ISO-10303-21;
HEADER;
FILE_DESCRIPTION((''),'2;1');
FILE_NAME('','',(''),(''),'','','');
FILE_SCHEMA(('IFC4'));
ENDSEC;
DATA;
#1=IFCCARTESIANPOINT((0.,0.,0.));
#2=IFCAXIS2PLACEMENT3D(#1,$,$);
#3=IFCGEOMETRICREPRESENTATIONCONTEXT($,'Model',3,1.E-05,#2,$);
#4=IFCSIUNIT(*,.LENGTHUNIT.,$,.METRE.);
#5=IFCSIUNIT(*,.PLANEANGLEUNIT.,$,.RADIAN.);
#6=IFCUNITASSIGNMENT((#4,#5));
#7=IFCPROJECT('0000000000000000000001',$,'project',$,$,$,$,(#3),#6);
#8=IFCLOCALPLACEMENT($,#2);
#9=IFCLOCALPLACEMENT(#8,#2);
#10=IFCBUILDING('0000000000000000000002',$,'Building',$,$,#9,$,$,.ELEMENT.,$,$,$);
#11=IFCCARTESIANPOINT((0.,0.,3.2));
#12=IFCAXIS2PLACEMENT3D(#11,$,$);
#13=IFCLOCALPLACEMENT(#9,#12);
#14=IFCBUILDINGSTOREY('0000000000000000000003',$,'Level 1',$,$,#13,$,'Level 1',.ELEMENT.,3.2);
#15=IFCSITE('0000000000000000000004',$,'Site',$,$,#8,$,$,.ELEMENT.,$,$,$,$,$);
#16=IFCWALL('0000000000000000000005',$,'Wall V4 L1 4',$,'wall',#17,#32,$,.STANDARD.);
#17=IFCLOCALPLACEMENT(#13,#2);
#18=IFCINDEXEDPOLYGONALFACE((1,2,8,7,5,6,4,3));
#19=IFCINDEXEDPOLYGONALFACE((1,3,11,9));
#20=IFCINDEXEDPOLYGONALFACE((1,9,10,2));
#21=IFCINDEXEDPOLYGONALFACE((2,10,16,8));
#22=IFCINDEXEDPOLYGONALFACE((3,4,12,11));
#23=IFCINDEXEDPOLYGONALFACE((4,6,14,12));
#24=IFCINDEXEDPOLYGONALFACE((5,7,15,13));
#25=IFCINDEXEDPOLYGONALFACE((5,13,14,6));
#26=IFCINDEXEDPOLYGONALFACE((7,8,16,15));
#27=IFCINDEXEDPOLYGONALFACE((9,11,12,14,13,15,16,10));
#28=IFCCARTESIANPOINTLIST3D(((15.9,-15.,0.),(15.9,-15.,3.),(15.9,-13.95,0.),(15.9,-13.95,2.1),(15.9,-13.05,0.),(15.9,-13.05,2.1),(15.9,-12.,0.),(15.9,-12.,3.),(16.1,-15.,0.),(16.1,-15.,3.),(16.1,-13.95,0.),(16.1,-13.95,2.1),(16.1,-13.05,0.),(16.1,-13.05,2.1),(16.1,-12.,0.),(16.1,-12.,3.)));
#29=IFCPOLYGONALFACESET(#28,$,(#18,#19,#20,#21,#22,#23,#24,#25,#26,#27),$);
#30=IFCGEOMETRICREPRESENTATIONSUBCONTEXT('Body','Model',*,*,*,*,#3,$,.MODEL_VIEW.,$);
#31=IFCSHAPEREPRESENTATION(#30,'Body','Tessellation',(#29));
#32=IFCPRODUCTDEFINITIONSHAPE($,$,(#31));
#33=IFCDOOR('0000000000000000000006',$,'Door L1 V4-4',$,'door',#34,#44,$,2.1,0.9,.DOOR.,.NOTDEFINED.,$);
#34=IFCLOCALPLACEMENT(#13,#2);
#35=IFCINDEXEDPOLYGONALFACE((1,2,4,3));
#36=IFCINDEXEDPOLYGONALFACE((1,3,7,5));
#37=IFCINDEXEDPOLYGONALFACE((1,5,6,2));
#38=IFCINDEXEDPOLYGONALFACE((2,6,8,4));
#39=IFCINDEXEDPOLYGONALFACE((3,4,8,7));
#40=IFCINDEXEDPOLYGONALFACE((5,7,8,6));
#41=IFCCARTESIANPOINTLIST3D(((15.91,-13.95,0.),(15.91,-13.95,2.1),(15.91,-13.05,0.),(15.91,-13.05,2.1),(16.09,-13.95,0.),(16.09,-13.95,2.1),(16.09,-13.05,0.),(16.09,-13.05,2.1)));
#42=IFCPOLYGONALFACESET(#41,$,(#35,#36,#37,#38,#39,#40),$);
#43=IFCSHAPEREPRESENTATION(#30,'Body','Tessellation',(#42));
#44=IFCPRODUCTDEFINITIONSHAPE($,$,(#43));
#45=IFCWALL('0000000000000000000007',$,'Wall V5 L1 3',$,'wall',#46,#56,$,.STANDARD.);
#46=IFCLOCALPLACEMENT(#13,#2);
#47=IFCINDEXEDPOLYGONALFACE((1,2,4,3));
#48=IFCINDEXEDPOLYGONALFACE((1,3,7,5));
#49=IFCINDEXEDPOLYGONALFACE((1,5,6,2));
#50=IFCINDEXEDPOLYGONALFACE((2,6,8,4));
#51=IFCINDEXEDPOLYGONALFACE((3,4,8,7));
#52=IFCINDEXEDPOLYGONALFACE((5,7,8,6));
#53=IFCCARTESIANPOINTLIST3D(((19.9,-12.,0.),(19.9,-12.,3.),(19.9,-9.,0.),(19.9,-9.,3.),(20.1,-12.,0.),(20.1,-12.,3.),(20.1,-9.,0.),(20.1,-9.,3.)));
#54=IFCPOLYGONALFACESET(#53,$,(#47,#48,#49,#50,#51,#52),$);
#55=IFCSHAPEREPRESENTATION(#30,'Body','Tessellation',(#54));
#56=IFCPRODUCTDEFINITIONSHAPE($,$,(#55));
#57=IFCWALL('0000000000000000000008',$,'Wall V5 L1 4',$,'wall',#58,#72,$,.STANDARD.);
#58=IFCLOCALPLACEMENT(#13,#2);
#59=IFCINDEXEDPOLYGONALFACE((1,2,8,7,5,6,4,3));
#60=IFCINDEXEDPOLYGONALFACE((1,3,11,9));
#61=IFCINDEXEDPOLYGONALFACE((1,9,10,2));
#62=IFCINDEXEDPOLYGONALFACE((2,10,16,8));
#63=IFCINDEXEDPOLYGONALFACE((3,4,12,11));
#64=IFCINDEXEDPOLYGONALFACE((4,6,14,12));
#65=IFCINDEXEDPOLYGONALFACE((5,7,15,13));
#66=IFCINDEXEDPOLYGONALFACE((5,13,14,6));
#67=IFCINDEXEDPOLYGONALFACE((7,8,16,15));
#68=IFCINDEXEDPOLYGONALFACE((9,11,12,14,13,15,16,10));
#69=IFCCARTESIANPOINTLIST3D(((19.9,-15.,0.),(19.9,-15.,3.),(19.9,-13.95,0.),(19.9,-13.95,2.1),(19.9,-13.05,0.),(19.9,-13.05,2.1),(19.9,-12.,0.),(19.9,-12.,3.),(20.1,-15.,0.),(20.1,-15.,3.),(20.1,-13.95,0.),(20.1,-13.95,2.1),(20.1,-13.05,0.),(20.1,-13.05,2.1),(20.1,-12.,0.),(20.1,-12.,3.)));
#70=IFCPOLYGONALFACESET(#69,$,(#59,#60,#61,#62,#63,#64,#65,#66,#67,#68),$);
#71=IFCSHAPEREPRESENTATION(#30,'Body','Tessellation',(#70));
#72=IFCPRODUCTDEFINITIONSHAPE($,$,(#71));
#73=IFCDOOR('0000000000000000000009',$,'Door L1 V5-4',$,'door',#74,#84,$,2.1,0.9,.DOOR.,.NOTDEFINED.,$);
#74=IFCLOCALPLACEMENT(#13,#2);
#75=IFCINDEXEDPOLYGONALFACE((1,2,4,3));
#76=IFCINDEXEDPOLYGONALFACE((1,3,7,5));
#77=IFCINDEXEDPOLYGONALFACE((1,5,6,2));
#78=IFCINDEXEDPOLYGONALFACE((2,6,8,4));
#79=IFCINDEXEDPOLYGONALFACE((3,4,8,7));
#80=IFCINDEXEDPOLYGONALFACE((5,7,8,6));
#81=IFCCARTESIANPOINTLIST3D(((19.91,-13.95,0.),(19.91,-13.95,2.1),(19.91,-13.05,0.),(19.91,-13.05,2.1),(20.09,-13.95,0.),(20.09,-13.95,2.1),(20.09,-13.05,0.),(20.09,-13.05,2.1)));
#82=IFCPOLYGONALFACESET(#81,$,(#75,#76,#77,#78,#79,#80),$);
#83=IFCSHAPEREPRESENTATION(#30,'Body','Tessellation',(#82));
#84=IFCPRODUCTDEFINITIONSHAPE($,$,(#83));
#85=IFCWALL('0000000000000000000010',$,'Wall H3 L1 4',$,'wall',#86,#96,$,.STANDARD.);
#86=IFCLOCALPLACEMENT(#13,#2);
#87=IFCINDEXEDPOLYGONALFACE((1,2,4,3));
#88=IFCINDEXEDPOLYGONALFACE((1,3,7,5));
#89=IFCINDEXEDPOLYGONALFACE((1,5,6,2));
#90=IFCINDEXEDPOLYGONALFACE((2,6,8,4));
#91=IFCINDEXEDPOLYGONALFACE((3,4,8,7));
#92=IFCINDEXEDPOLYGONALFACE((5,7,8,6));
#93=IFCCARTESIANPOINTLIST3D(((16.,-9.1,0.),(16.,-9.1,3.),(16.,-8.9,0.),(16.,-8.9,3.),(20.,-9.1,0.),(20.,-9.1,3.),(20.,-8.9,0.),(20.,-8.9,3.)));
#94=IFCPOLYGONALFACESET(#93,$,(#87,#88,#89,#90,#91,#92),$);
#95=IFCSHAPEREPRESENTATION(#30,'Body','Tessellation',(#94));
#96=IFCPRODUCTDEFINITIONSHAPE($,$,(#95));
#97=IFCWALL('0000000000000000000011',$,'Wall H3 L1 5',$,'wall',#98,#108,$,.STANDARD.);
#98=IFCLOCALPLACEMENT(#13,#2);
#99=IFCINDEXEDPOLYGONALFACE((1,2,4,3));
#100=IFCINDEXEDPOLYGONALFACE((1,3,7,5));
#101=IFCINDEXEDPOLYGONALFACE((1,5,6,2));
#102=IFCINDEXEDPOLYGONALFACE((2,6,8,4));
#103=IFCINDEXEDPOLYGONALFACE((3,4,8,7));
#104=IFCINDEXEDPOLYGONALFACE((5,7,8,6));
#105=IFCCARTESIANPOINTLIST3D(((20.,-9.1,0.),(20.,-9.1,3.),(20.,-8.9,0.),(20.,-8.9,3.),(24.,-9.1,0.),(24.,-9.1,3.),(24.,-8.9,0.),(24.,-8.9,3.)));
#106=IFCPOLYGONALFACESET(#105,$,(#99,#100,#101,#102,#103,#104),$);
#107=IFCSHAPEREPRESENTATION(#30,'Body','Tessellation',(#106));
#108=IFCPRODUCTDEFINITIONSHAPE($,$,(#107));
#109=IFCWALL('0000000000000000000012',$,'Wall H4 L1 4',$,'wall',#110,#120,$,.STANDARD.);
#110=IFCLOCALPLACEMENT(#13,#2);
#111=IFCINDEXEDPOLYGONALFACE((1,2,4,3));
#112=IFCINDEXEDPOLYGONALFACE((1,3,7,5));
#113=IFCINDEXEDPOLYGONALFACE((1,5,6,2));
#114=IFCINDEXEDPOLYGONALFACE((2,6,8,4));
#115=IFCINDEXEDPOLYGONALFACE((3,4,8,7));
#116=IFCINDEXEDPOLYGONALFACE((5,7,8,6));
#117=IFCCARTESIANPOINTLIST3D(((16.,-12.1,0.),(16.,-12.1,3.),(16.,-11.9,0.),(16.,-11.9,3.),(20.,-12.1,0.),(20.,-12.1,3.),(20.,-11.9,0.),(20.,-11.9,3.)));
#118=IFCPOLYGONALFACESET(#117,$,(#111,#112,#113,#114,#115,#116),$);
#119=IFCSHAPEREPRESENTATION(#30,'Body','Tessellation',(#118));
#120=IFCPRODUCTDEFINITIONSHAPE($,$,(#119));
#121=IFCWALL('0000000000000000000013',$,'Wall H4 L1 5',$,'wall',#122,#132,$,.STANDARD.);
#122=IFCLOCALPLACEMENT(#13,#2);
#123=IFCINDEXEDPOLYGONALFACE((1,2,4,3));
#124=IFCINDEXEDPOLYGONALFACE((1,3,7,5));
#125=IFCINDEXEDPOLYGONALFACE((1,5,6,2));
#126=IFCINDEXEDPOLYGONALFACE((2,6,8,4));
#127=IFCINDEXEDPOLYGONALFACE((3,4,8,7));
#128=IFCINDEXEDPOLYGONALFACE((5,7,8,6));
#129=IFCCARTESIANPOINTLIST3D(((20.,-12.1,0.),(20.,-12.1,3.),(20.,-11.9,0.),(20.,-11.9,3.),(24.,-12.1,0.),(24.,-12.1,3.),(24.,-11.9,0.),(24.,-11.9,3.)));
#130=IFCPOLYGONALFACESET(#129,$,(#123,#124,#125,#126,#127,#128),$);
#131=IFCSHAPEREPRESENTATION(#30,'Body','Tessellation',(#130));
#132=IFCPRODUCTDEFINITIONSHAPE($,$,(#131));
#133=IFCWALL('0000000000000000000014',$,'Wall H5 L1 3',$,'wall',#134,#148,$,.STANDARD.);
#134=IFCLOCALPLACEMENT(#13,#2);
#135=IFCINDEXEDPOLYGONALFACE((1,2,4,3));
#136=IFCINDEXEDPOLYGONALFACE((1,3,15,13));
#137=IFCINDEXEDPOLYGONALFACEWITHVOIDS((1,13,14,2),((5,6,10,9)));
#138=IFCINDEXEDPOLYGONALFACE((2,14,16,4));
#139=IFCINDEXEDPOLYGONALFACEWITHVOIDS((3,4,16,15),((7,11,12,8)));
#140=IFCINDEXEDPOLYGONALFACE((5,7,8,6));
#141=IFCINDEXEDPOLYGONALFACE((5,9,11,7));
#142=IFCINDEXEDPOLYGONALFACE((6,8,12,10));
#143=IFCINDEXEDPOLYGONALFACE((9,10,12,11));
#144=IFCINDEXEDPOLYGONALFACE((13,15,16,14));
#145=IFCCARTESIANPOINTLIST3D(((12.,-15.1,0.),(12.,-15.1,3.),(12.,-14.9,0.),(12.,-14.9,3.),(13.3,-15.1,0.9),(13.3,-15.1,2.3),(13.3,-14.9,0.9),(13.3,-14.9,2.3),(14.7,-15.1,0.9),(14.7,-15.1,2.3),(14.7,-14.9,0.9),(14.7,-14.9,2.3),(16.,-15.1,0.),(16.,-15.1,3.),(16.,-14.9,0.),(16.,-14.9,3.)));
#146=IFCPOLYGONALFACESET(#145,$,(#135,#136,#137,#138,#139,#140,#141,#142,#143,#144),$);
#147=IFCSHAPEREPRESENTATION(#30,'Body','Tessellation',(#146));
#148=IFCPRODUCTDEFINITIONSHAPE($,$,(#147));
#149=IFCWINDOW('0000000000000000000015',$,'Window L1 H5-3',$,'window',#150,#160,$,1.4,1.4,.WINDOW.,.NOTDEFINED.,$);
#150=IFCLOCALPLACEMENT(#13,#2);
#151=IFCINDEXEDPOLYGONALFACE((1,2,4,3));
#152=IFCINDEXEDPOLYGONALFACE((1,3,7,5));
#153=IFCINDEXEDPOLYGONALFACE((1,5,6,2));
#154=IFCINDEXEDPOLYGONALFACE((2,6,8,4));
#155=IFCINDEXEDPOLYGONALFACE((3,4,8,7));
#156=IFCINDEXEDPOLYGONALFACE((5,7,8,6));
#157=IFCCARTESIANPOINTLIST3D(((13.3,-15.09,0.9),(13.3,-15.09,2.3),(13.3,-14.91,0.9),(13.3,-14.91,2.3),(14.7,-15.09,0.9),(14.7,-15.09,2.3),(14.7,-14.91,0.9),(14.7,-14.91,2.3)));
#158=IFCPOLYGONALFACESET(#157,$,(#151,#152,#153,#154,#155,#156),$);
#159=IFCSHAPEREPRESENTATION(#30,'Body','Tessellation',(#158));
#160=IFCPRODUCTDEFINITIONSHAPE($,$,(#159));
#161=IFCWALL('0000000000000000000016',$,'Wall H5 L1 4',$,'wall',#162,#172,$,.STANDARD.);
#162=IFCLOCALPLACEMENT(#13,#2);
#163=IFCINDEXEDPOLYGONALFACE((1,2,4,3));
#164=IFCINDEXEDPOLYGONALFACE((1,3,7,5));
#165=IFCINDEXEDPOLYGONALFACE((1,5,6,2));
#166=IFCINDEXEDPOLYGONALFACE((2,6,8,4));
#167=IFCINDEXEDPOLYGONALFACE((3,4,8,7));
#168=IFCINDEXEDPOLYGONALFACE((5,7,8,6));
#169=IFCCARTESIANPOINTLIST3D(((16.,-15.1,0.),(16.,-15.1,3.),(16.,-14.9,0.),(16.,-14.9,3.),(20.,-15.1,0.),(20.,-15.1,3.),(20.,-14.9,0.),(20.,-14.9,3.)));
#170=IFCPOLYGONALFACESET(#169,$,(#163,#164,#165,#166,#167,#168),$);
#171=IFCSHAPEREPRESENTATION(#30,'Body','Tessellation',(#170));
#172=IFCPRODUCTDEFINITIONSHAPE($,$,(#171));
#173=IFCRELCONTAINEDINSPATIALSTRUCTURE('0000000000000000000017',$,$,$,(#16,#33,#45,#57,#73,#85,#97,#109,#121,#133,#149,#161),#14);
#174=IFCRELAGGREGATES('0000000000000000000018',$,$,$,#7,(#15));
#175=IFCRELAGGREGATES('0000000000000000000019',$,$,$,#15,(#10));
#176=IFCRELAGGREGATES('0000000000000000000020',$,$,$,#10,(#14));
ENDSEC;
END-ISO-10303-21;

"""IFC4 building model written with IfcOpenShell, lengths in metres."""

from ifc_helpers import new_model, si_unit, frame, frame_2d, origin, origin_2d, place, context, subcontext, project, spatial, rectangle, extrude, element, fill, save


model = new_model("IFC4")

# Units and contexts
model_context = context("Model", 3, precision=1e-05, world=origin())
body_context = subcontext(model_context, "Body", "Model", "MODEL_VIEW")
ifc_project = project(units=[si_unit("LENGTHUNIT", "METRE"), si_unit("PLANEANGLEUNIT", "RADIAN")], contexts=[model_context])

# Site, building, storey
site_placement = place(None, origin())
site = spatial("IfcSite", under=ifc_project, at=site_placement, Name="Site", CompositionType="ELEMENT")
building_placement = place(site_placement, origin())
building = spatial("IfcBuilding", under=site, at=building_placement, Name="Building", CompositionType="ELEMENT")
storey_placement = place(building_placement, frame((0.0, 0.0, 3.2)))
storey = spatial("IfcBuildingStorey", under=building, at=storey_placement, Name="Level 1", LongName="Level 1", CompositionType="ELEMENT", Elevation=3.2)

# Wall, opening, door
wall_1_placement = place(storey_placement, frame((16.0, -12.0, 0.0), z_axis=(0.0, 0.0, 1.0), x_axis=(0.0, -1.0, 0.0)))
wall_1 = element("IfcWall", 1, at=wall_1_placement, inside=storey, Name="Wall V4 L1 4", ObjectType="wall", PredefinedType="STANDARD", context=body_context, shape_type="SweptSolid", body=[
    extrude(rectangle(XDim=3.0, YDim=0.2, at=frame_2d((1.5, 0.0))), origin(), (0.0, 0.0, 1.0), 3.0),
])
opening_1_placement = place(storey_placement, frame((16.0, -13.5, 0.0), z_axis=(0.0, 0.0, 1.0), x_axis=(0.0, -1.0, 0.0)))
opening_1 = element("IfcOpeningElement", 2, at=opening_1_placement, cuts=wall_1, ObjectType="Opening", PredefinedType="OPENING", context=body_context, shape_type="SweptSolid", body=[
    extrude(rectangle(XDim=0.9, YDim=0.22, at=origin_2d()), origin(), (0.0, 0.0, 1.0), 2.1),
])
door_1_placement = place(storey_placement, frame((16.0, -13.5, 0.0), z_axis=(0.0, 0.0, 1.0), x_axis=(0.0, -1.0, 0.0)))
door_1 = element("IfcDoor", 3, at=door_1_placement, inside=storey, Name="Door L1 V4-4", ObjectType="door", OperationType="NOTDEFINED", OverallHeight=2.1, OverallWidth=0.9, PredefinedType="DOOR", context=body_context, shape_type="SweptSolid", body=[
    extrude(rectangle(XDim=0.9, YDim=0.18, at=origin_2d()), origin(), (0.0, 0.0, 1.0), 2.1),
])
fill(opening_1, door_1)

# Wall
wall_2_placement = place(storey_placement, frame((20.0, -9.0, 0.0), z_axis=(0.0, 0.0, 1.0), x_axis=(0.0, -1.0, 0.0)))
element("IfcWall", 4, at=wall_2_placement, inside=storey, Name="Wall V5 L1 3", ObjectType="wall", PredefinedType="STANDARD", context=body_context, shape_type="SweptSolid", body=[
    extrude(rectangle(XDim=3.0, YDim=0.2, at=frame_2d((1.5, 0.0))), origin(), (0.0, 0.0, 1.0), 3.0),
])

# Wall, opening, door
wall_3_placement = place(storey_placement, frame((20.0, -12.0, 0.0), z_axis=(0.0, 0.0, 1.0), x_axis=(0.0, -1.0, 0.0)))
wall_3 = element("IfcWall", 5, at=wall_3_placement, inside=storey, Name="Wall V5 L1 4", ObjectType="wall", PredefinedType="STANDARD", context=body_context, shape_type="SweptSolid", body=[
    extrude(rectangle(XDim=3.0, YDim=0.2, at=frame_2d((1.5, 0.0))), origin(), (0.0, 0.0, 1.0), 3.0),
])
opening_2_placement = place(storey_placement, frame((20.0, -13.5, 0.0), z_axis=(0.0, 0.0, 1.0), x_axis=(0.0, -1.0, 0.0)))
opening_2 = element("IfcOpeningElement", 6, at=opening_2_placement, cuts=wall_3, ObjectType="Opening", PredefinedType="OPENING", context=body_context, shape_type="SweptSolid", body=[
    extrude(rectangle(XDim=0.9, YDim=0.22, at=origin_2d()), origin(), (0.0, 0.0, 1.0), 2.1),
])
door_2_placement = place(storey_placement, frame((20.0, -13.5, 0.0), z_axis=(0.0, 0.0, 1.0), x_axis=(0.0, -1.0, 0.0)))
door_2 = element("IfcDoor", 7, at=door_2_placement, inside=storey, Name="Door L1 V5-4", ObjectType="door", OperationType="NOTDEFINED", OverallHeight=2.1, OverallWidth=0.9, PredefinedType="DOOR", context=body_context, shape_type="SweptSolid", body=[
    extrude(rectangle(XDim=0.9, YDim=0.18, at=origin_2d()), origin(), (0.0, 0.0, 1.0), 2.1),
])
fill(opening_2, door_2)

# Walls
for number, where, z_axis, x_axis, name in (
    (8, (16.0, -9.0, 0.0), (0.0, 0.0, 1.0), (1.0, 0.0, 0.0), "Wall H3 L1 4"),
    (9, (20.0, -9.0, 0.0), (0.0, 0.0, 1.0), (1.0, 0.0, 0.0), "Wall H3 L1 5"),
    (10, (16.0, -12.0, 0.0), (0.0, 0.0, 1.0), (1.0, 0.0, 0.0), "Wall H4 L1 4"),
    (11, (20.0, -12.0, 0.0), (0.0, 0.0, 1.0), (1.0, 0.0, 0.0), "Wall H4 L1 5"),
):
    element("IfcWall", number, at=place(storey_placement, frame(where, z_axis=z_axis, x_axis=x_axis)), inside=storey, Name=name, ObjectType="wall", PredefinedType="STANDARD", context=body_context, shape_type="SweptSolid", body=[
        extrude(rectangle(XDim=4.0, YDim=0.2, at=frame_2d((2.0, 0.0))), origin(), (0.0, 0.0, 1.0), 3.0),
    ])

# Wall, opening, window
wall_4_placement = place(storey_placement, frame((12.0, -15.0, 0.0), z_axis=(0.0, 0.0, 1.0), x_axis=(1.0, 0.0, 0.0)))
wall_4 = element("IfcWall", 12, at=wall_4_placement, inside=storey, Name="Wall H5 L1 3", ObjectType="wall", PredefinedType="STANDARD", context=body_context, shape_type="SweptSolid", body=[
    extrude(rectangle(XDim=4.0, YDim=0.2, at=frame_2d((2.0, 0.0))), origin(), (0.0, 0.0, 1.0), 3.0),
])
opening_3_placement = place(storey_placement, frame((14.0, -15.0, 0.9), z_axis=(0.0, 0.0, 1.0), x_axis=(1.0, 0.0, 0.0)))
opening_3 = element("IfcOpeningElement", 13, at=opening_3_placement, cuts=wall_4, ObjectType="Opening", PredefinedType="OPENING", context=body_context, shape_type="SweptSolid", body=[
    extrude(rectangle(XDim=1.4, YDim=0.22, at=origin_2d()), origin(), (0.0, 0.0, 1.0), 1.4),
])
window_1_placement = place(storey_placement, frame((14.0, -15.0, 0.9), z_axis=(0.0, 0.0, 1.0), x_axis=(1.0, 0.0, 0.0)))
window_1 = element("IfcWindow", 14, at=window_1_placement, inside=storey, Name="Window L1 H5-3", ObjectType="window", OverallHeight=1.4, OverallWidth=1.4, PartitioningType="NOTDEFINED", PredefinedType="WINDOW", context=body_context, shape_type="SweptSolid", body=[
    extrude(rectangle(XDim=1.4, YDim=0.18, at=origin_2d()), origin(), (0.0, 0.0, 1.0), 1.4),
])
fill(opening_3, window_1)

# Wall
wall_5_placement = place(storey_placement, frame((16.0, -15.0, 0.0), z_axis=(0.0, 0.0, 1.0), x_axis=(1.0, 0.0, 0.0)))
element("IfcWall", 15, at=wall_5_placement, inside=storey, Name="Wall H5 L1 4", ObjectType="wall", PredefinedType="STANDARD", context=body_context, shape_type="SweptSolid", body=[
    extrude(rectangle(XDim=4.0, YDim=0.2, at=frame_2d((2.0, 0.0))), origin(), (0.0, 0.0, 1.0), 3.0),
])

save(model, "model.ifc")
